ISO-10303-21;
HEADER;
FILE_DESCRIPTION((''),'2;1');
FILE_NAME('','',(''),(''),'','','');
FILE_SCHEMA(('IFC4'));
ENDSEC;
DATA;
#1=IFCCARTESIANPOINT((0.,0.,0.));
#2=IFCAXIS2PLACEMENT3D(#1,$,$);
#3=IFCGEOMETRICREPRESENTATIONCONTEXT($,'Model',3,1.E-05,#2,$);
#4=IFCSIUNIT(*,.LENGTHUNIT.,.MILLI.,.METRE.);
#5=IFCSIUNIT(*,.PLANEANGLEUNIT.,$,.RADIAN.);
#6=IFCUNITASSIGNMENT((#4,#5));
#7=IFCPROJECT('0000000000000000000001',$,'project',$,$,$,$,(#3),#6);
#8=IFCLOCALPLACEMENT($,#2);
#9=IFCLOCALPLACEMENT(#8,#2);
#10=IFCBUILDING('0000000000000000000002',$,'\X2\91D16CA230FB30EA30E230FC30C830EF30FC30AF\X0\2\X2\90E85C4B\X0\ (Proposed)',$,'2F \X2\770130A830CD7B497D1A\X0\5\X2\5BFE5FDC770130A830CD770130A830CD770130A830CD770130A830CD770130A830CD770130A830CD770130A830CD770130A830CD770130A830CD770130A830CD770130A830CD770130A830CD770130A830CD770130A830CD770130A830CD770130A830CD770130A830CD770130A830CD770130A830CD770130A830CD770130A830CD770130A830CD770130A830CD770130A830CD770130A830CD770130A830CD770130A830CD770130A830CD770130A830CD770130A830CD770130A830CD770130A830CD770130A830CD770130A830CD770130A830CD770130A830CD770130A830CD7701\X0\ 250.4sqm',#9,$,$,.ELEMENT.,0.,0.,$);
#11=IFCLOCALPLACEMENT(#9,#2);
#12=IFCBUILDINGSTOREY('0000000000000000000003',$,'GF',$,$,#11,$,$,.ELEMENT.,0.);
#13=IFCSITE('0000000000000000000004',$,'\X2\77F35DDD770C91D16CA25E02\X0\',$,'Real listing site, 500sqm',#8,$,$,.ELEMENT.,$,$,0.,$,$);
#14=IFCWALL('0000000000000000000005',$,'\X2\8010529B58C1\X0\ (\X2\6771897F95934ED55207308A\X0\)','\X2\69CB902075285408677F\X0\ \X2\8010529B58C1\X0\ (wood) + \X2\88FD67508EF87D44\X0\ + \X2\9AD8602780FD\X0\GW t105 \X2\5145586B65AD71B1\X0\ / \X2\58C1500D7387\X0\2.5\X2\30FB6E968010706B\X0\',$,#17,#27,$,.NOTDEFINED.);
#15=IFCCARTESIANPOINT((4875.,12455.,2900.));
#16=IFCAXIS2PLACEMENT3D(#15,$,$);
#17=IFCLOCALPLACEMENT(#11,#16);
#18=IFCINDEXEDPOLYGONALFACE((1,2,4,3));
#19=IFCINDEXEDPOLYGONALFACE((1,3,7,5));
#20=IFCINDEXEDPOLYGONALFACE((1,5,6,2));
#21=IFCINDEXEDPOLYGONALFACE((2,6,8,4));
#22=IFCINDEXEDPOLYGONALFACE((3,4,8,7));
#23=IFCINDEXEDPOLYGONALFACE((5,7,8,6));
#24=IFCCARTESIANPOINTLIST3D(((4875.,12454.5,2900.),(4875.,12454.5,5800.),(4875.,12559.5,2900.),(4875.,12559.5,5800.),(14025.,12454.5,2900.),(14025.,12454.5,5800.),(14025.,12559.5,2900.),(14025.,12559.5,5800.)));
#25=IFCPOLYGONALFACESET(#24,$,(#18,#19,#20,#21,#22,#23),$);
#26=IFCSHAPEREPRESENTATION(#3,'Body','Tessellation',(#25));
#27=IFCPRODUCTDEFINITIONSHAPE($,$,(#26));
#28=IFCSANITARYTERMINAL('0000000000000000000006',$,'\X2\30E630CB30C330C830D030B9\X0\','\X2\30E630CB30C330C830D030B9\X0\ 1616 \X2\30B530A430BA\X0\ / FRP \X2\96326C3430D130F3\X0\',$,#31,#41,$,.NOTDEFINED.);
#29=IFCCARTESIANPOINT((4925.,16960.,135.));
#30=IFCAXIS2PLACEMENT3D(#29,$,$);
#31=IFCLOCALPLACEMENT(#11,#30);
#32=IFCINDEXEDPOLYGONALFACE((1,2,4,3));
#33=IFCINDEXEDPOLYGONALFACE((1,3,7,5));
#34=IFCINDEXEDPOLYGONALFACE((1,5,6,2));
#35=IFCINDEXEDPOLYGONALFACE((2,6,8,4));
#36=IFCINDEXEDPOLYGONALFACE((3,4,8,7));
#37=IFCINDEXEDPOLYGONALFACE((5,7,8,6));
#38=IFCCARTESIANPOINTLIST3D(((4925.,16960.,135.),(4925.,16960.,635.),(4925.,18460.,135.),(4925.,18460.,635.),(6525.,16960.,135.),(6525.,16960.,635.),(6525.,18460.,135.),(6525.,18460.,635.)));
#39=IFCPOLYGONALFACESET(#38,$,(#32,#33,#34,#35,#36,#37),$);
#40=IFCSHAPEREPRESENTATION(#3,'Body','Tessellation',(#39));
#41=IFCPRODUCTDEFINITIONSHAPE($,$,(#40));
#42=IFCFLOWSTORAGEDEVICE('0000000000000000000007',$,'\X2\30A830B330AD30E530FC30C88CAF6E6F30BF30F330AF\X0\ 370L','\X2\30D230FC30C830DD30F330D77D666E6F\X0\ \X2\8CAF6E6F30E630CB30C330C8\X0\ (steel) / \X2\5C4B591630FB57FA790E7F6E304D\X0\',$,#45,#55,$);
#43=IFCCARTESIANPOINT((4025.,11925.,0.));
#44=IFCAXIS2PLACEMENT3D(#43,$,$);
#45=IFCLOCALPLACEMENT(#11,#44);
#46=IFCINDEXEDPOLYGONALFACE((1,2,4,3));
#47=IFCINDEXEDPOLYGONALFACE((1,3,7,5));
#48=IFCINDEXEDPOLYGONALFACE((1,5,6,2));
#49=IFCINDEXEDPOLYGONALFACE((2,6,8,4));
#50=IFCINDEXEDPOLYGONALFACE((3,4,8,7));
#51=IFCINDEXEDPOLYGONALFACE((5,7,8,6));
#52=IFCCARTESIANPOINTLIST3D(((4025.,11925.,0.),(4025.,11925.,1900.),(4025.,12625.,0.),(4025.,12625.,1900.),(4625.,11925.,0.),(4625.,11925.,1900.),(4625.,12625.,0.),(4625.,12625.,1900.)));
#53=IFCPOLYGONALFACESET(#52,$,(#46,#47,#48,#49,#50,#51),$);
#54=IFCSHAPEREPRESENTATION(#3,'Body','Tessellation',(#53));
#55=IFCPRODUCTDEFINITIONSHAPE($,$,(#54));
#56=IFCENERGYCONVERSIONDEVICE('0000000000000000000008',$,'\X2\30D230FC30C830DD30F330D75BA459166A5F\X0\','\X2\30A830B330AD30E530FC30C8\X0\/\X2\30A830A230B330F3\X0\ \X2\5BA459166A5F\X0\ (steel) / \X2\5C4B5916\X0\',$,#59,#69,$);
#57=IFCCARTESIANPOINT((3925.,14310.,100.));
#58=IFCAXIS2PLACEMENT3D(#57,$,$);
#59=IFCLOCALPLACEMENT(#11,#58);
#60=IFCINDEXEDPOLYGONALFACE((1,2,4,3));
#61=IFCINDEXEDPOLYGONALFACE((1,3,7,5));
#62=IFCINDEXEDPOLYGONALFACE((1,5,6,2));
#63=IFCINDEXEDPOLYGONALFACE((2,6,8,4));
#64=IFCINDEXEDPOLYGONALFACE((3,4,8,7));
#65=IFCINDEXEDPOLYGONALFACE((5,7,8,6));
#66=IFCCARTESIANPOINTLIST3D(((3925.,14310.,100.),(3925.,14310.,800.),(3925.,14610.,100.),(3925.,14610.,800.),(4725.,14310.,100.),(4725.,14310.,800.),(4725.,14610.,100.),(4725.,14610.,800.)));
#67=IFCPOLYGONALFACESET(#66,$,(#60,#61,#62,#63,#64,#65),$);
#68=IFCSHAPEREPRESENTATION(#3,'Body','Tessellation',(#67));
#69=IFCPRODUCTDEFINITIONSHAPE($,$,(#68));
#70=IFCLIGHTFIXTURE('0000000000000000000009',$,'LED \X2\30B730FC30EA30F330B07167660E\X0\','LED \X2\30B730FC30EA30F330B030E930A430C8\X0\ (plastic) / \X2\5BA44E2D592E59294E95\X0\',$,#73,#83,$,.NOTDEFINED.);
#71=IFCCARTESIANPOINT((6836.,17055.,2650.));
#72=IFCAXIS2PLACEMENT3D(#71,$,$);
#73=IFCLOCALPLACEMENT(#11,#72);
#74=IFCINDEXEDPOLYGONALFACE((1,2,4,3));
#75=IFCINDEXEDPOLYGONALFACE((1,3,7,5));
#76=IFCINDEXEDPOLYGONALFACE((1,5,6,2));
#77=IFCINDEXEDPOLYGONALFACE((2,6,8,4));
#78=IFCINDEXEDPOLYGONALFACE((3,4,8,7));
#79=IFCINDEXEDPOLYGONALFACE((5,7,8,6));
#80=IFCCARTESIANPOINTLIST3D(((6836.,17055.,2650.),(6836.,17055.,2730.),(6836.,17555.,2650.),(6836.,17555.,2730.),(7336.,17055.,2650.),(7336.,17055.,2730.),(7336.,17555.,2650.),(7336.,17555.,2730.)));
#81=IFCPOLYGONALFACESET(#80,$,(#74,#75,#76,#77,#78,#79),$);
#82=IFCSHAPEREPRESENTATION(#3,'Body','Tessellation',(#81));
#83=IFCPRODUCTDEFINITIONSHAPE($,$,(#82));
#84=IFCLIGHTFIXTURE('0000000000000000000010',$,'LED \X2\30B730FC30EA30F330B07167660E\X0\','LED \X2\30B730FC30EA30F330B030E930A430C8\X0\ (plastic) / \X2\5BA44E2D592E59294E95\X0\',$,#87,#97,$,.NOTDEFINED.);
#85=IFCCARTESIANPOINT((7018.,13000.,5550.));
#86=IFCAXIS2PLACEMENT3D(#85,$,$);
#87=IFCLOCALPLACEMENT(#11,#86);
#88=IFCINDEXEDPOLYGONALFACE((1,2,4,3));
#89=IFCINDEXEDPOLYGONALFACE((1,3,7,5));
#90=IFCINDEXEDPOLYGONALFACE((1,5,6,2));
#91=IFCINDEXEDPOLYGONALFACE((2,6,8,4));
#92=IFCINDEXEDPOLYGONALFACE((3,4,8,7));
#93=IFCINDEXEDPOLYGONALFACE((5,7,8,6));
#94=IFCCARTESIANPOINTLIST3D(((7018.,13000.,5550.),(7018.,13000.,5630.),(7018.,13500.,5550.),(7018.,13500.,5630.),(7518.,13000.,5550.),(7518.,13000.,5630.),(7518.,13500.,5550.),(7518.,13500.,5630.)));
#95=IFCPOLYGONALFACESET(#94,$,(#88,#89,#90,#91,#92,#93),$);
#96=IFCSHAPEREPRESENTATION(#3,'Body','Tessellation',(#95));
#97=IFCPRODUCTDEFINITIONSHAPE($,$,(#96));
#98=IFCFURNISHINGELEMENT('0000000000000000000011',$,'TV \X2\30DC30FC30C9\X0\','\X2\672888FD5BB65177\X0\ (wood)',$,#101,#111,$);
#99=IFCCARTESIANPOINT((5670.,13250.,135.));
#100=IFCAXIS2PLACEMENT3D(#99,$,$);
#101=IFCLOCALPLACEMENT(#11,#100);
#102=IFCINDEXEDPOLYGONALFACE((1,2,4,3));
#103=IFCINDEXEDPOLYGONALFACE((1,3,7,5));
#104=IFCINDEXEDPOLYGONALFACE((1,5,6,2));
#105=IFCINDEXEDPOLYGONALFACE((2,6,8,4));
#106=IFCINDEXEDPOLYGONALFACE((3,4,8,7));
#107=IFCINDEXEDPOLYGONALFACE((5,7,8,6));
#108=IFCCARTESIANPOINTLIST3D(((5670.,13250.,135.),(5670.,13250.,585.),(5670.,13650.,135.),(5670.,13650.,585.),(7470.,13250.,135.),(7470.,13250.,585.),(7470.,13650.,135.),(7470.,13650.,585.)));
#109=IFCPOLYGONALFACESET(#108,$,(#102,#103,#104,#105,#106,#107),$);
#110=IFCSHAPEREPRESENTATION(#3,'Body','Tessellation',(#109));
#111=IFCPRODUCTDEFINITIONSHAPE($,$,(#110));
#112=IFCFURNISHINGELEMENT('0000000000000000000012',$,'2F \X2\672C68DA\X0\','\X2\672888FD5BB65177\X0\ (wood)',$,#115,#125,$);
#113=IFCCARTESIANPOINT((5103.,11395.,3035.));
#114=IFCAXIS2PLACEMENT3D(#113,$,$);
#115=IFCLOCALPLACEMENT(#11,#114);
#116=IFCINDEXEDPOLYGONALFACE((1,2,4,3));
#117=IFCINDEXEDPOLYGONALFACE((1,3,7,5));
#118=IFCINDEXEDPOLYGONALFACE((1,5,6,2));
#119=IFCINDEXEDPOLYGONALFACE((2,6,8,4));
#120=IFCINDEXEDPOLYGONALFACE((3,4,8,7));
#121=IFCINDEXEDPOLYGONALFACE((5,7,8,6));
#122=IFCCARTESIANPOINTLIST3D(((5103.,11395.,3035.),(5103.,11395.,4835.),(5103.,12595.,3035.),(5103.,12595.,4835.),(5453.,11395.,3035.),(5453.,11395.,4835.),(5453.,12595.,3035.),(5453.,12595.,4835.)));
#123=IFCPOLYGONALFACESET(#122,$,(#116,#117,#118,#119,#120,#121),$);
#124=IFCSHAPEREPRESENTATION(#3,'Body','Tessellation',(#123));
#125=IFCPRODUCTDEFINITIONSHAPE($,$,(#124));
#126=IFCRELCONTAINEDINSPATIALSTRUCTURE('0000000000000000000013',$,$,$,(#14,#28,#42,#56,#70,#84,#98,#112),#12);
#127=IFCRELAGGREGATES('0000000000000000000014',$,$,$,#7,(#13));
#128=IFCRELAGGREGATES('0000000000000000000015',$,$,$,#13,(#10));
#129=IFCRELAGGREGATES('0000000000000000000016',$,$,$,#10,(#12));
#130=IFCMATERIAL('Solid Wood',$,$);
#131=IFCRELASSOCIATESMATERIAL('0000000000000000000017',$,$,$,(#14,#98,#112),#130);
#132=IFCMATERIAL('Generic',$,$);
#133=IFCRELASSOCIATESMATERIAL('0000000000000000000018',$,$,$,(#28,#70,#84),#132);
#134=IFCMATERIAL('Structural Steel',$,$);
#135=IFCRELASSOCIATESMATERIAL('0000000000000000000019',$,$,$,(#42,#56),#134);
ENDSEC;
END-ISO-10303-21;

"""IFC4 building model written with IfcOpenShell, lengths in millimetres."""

from ifc_helpers import new_model, si_unit, frame, frame_2d, origin, place, context, project, spatial, rectangle, extrude, material, element, save


model = new_model("IFC4")

# Units and contexts
model_context = context("Model", 3, precision=1e-05, world=origin())
ifc_project = project(units=[si_unit("LENGTHUNIT", "METRE", prefix="MILLI"), si_unit("PLANEANGLEUNIT", "RADIAN")], contexts=[model_context])

# Site, building, storey
site_placement = place(None, origin())
site = spatial("IfcSite", under=ifc_project, at=site_placement, Name="石川県金沢市", ObjectType="Real listing site, 500sqm", CompositionType="ELEMENT", RefElevation=0.0)
building_placement = place(site_placement, origin())
building = spatial("IfcBuilding", under=site, at=building_placement, Name="金沢・リモートワーク2部屋 (Proposed)", ObjectType="2F 省エネ等級5対応省エネ省エネ省エネ省エネ省エネ省エネ省エネ省エネ省エネ省エネ省エネ省エネ省エネ省エネ省エネ省エネ省エネ省エネ省エネ省エネ省エネ省エネ省エネ省エネ省エネ省エネ省エネ省エネ省エネ省エネ省エネ省エネ省エネ省エネ省エネ省エネ省エネ省 250.4sqm", CompositionType="ELEMENT", ElevationOfRefHeight=0.0, ElevationOfTerrain=0.0)
storey_placement = place(building_placement, origin())
storey = spatial("IfcBuildingStorey", under=building, at=storey_placement, Name="GF", CompositionType="ELEMENT", Elevation=0.0)

# Shared definitions
ifc_material_1 = material(Name="Solid Wood")

# Wall
wall_1_placement = place(storey_placement, frame((4875.0, 12455.0, 2900.0)))
element("IfcWall", 1, at=wall_1_placement, inside=storey, material=ifc_material_1, Name="耐力壁 (東西間仕切り)", Description="構造用合板 耐力壁 (wood) + 製材軸組 + 高性能GW t105 充填断熱 / 壁倍率2.5・準耐火", PredefinedType="NOTDEFINED", context=model_context, shape_type="SweptSolid", body=[
    extrude(rectangle(XDim=9150.0, YDim=105.0, at=frame_2d((4575.0, 52.0))), frame((4875.0, 12455.0, 2900.0)), (0.0, 0.0, 1.0), 2900.0),
])

# Sanitary terminal
ifc_material_2 = material(Name="Generic")
sanitary_terminal_placement = place(storey_placement, frame((4925.0, 16960.0, 135.0)))
element("IfcSanitaryTerminal", 2, at=sanitary_terminal_placement, inside=storey, material=ifc_material_2, Name="ユニットバス", Description="ユニットバス 1616 サイズ / FRP 防水パン", PredefinedType="NOTDEFINED", context=model_context, shape_type="SweptSolid", body=[
    extrude(rectangle(XDim=1600.0, YDim=1500.0, at=frame_2d((800.0, 750.0))), frame((4925.0, 16960.0, 135.0)), (0.0, 0.0, 1.0), 500.0),
])

# Flow storage device
ifc_material_3 = material(Name="Structural Steel")
flow_storage_device_placement = place(storey_placement, frame((4025.0, 11925.0, 0.0)))
element("IfcFlowStorageDevice", 3, at=flow_storage_device_placement, inside=storey, material=ifc_material_3, Name="エコキュート貯湯タンク 370L", Description="ヒートポンプ給湯 貯湯ユニット (steel) / 屋外・基礎置き", context=model_context, shape_type="SweptSolid", body=[
    extrude(rectangle(XDim=600.0, YDim=700.0, at=frame_2d((300.0, 350.0))), frame((4025.0, 11925.0, 0.0)), (0.0, 0.0, 1.0), 1900.0),
])

# Energy conversion device
energy_conversion_device_placement = place(storey_placement, frame((3925.0, 14310.0, 100.0)))
element("IfcEnergyConversionDevice", 4, at=energy_conversion_device_placement, inside=storey, material=ifc_material_3, Name="ヒートポンプ室外機", Description="エコキュート/エアコン 室外機 (steel) / 屋外", context=model_context, shape_type="SweptSolid", body=[
    extrude(rectangle(XDim=800.0, YDim=300.0, at=frame_2d((400.0, 150.0))), frame((3925.0, 14310.0, 100.0)), (0.0, 0.0, 1.0), 700.0),
])

# Light fixtures
light_fixture_1_placement = place(storey_placement, frame((6836.0, 17055.0, 2650.0)))
element("IfcLightFixture", 5, at=light_fixture_1_placement, inside=storey, material=ifc_material_2, Name="LED シーリング照明", Description="LED シーリングライト (plastic) / 室中央天井", PredefinedType="NOTDEFINED", context=model_context, shape_type="SweptSolid", body=[
    extrude(rectangle(XDim=500.0, YDim=500.0, at=frame_2d((250.0, 250.0))), frame((6836.0, 17055.0, 2650.0)), (0.0, 0.0, 1.0), 80.0),
])
light_fixture_2_placement = place(storey_placement, frame((7018.0, 13000.0, 5550.0)))
element("IfcLightFixture", 6, at=light_fixture_2_placement, inside=storey, material=ifc_material_2, Name="LED シーリング照明", Description="LED シーリングライト (plastic) / 室中央天井", PredefinedType="NOTDEFINED", context=model_context, shape_type="SweptSolid", body=[
    extrude(rectangle(XDim=500.0, YDim=500.0, at=frame_2d((250.0, 250.0))), frame((7018.0, 13000.0, 5550.0)), (0.0, 0.0, 1.0), 80.0),
])

# Furnishing elements
furnishing_1_placement = place(storey_placement, frame((5670.0, 13250.0, 135.0)))
element("IfcFurnishingElement", 7, at=furnishing_1_placement, inside=storey, material=ifc_material_1, Name="TV ボード", Description="木製家具 (wood)", context=model_context, shape_type="SweptSolid", body=[
    extrude(rectangle(XDim=1800.0, YDim=400.0, at=frame_2d((900.0, 200.0))), frame((5670.0, 13250.0, 135.0)), (0.0, 0.0, 1.0), 450.0),
])
furnishing_2_placement = place(storey_placement, frame((5103.0, 11395.0, 3035.0)))
element("IfcFurnishingElement", 8, at=furnishing_2_placement, inside=storey, material=ifc_material_1, Name="2F 本棚", Description="木製家具 (wood)", context=model_context, shape_type="SweptSolid", body=[
    extrude(rectangle(XDim=350.0, YDim=1200.0, at=frame_2d((175.0, 600.0))), frame((5103.0, 11395.0, 3035.0)), (0.0, 0.0, 1.0), 1800.0),
])

save(model, "model.ifc")
